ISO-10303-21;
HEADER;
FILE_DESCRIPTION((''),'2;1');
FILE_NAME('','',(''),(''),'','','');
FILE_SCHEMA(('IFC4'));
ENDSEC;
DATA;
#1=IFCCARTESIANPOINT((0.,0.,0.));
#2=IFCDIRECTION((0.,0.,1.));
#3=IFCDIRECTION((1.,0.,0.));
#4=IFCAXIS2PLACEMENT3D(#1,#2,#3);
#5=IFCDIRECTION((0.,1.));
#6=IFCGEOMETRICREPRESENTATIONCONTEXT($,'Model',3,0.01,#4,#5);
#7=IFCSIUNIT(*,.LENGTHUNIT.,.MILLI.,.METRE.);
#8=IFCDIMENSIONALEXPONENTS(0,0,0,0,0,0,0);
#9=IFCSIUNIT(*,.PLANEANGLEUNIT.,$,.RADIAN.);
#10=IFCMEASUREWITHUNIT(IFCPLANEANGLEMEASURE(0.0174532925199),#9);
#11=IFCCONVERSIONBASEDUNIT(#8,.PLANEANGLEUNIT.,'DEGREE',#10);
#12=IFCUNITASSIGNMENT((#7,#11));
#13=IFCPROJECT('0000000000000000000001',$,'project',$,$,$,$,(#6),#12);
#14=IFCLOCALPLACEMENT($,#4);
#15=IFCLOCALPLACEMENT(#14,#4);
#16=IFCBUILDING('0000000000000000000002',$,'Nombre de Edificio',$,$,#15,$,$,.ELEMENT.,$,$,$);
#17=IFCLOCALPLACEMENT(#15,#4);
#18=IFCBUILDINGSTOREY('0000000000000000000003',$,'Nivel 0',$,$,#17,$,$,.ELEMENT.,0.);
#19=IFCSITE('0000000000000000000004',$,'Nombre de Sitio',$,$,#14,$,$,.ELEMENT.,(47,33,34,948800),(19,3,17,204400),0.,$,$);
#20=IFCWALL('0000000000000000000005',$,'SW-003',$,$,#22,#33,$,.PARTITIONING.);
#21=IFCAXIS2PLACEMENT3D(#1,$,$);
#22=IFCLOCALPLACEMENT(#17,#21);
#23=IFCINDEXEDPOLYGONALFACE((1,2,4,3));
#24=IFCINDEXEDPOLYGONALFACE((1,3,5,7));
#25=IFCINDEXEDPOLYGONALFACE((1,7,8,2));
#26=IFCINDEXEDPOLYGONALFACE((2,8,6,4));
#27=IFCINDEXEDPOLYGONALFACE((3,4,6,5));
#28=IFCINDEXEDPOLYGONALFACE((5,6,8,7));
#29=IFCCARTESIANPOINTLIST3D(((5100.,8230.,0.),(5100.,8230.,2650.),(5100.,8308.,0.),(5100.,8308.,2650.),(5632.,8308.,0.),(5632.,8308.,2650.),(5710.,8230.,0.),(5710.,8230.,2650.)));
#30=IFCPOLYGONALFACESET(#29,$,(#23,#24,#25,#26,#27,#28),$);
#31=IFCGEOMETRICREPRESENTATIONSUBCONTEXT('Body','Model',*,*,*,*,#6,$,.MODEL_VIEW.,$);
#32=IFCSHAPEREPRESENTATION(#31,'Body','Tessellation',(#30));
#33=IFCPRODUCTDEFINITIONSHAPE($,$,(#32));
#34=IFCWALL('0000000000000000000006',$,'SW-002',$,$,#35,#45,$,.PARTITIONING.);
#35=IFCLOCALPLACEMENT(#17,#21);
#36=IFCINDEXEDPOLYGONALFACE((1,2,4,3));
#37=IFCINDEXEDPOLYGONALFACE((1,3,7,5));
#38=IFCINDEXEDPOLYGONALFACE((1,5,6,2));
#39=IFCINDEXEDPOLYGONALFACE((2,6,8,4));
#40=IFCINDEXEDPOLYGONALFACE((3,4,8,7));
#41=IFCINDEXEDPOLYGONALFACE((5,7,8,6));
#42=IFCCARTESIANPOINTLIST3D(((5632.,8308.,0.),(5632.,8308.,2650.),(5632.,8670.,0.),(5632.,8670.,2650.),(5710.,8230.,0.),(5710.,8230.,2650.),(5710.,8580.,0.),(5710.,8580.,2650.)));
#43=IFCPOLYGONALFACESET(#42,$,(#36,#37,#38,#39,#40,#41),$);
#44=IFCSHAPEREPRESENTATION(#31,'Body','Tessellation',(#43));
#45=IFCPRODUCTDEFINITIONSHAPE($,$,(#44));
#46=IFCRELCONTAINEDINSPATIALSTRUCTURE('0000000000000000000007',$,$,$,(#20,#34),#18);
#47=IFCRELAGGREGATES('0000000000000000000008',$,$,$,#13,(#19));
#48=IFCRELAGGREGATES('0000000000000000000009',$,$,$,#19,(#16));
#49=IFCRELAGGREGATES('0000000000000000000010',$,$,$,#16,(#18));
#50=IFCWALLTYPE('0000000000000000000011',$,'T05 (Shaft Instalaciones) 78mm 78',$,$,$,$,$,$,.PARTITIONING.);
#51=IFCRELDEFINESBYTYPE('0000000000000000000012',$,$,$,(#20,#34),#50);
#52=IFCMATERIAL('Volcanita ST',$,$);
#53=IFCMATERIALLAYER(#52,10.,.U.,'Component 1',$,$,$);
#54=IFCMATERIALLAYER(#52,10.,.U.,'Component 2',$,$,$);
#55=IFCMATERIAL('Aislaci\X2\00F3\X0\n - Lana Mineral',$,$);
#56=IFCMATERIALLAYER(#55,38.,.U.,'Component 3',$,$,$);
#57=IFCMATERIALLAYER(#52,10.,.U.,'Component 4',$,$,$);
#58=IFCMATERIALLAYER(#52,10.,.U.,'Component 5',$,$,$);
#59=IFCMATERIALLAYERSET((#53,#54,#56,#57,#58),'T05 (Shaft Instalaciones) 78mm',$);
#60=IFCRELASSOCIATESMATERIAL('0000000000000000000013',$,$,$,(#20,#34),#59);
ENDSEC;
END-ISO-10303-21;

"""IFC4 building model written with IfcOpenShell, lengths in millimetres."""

from ifc_helpers import new_model, entity, si_unit, converted_unit, direction, frame, origin_with_axes, place, context, subcontext, project, spatial, line, indexed_curve, outline, extrude, material, layer, layer_set, layer_usage, type_object, element, save


model = new_model("IFC4")

# Units and contexts
model_context = context("Model", 3, precision=0.01, world=origin_with_axes(), true_north=direction((0.0, 1.0)))
body_context = subcontext(model_context, "Body", "Model", "MODEL_VIEW")
ifc_project = project(units=[si_unit("LENGTHUNIT", "METRE", prefix="MILLI"), converted_unit("PLANEANGLEUNIT", "DEGREE", entity("IfcPlaneAngleMeasure", 0.0174532925199), si_unit("PLANEANGLEUNIT", "RADIAN"), dimensions=[0, 0, 0, 0, 0, 0, 0])], contexts=[model_context])

# Site, building, storey
site_placement = place(None, origin_with_axes())
site = spatial("IfcSite", under=ifc_project, at=site_placement, Name="Nombre de Sitio", CompositionType="ELEMENT", RefLatitude=(47, 33, 34, 948800), RefLongitude=(19, 3, 17, 204400), RefElevation=0.0)
building_placement = place(site_placement, origin_with_axes())
building = spatial("IfcBuilding", under=site, at=building_placement, Name="Nombre de Edificio", CompositionType="ELEMENT")
storey_placement = place(building_placement, origin_with_axes())
storey = spatial("IfcBuildingStorey", under=building, at=storey_placement, Name="Nivel 0", CompositionType="ELEMENT", Elevation=0.0)

# Shared definitions
ifc_material_1 = material(Name="Aislación - Lana Mineral")

# Walls
ifc_material_2 = material(Name="Volcanita ST")
ifc_layer_1 = layer(ifc_material_2, 10.0, ventilated="UNKNOWN", Name="Component 1")
ifc_layer_2 = layer(ifc_material_2, 10.0, ventilated="UNKNOWN", Name="Component 2")
ifc_layer_3 = layer(ifc_material_1, 38.0, ventilated="UNKNOWN", Name="Component 3")
ifc_layer_4 = layer(ifc_material_2, 10.0, ventilated="UNKNOWN", Name="Component 4")
ifc_layer_5 = layer(ifc_material_2, 10.0, ventilated="UNKNOWN", Name="Component 5")
ifc_layer_set_1 = layer_set([ifc_layer_1, ifc_layer_2, ifc_layer_3, ifc_layer_4, ifc_layer_5], Name="T05 (Shaft Instalaciones) 78mm")
ifc_layer_usage_1 = layer_usage(ifc_layer_set_1, "AXIS2", "POSITIVE", -39.0)
wall_type_1 = type_object("IfcWallType", Name="T05 (Shaft Instalaciones) 78mm 78", PredefinedType="PARTITIONING")
wall_1_placement = place(storey_placement, frame((5671.0, 8269.0, 0.0), z_axis=(0.0, 0.0, 1.0), x_axis=(-1.0, 0.0, 0.0)))
element("IfcWall", 1, at=wall_1_placement, inside=storey, type_object=wall_type_1, material=ifc_layer_usage_1, Name="SW-003", PredefinedType="PARTITIONING", context=body_context, shape_type="SweptSolid", body=[
    extrude(outline(indexed_curve([(39.0, -39.0), (571.0, -39.0), (571.0, 39.0), (-39.0, 39.0)], segments=[line(1, 2, 3, 4, 1)])), origin_with_axes(), (0.0, 0.0, 1.0), 2650.0),
])
ifc_layer_usage_2 = layer_usage(ifc_layer_set_1, "AXIS2", "POSITIVE", -39.0)
wall_2_placement = place(storey_placement, frame((5671.0, 8625.0, 0.0), z_axis=(0.0, 0.0, 1.0), x_axis=(0.0, -1.0, 0.0)))
element("IfcWall", 2, at=wall_2_placement, inside=storey, type_object=wall_type_1, material=ifc_layer_usage_2, Name="SW-002", PredefinedType="PARTITIONING", context=body_context, shape_type="SweptSolid", body=[
    extrude(outline(indexed_curve([(-45.0, -39.0), (317.0, -39.0), (395.0, 39.0), (45.0, 39.0)], segments=[line(1, 2, 3, 4, 1)])), origin_with_axes(), (0.0, 0.0, 1.0), 2650.0),
])

save(model, "model.ifc")
